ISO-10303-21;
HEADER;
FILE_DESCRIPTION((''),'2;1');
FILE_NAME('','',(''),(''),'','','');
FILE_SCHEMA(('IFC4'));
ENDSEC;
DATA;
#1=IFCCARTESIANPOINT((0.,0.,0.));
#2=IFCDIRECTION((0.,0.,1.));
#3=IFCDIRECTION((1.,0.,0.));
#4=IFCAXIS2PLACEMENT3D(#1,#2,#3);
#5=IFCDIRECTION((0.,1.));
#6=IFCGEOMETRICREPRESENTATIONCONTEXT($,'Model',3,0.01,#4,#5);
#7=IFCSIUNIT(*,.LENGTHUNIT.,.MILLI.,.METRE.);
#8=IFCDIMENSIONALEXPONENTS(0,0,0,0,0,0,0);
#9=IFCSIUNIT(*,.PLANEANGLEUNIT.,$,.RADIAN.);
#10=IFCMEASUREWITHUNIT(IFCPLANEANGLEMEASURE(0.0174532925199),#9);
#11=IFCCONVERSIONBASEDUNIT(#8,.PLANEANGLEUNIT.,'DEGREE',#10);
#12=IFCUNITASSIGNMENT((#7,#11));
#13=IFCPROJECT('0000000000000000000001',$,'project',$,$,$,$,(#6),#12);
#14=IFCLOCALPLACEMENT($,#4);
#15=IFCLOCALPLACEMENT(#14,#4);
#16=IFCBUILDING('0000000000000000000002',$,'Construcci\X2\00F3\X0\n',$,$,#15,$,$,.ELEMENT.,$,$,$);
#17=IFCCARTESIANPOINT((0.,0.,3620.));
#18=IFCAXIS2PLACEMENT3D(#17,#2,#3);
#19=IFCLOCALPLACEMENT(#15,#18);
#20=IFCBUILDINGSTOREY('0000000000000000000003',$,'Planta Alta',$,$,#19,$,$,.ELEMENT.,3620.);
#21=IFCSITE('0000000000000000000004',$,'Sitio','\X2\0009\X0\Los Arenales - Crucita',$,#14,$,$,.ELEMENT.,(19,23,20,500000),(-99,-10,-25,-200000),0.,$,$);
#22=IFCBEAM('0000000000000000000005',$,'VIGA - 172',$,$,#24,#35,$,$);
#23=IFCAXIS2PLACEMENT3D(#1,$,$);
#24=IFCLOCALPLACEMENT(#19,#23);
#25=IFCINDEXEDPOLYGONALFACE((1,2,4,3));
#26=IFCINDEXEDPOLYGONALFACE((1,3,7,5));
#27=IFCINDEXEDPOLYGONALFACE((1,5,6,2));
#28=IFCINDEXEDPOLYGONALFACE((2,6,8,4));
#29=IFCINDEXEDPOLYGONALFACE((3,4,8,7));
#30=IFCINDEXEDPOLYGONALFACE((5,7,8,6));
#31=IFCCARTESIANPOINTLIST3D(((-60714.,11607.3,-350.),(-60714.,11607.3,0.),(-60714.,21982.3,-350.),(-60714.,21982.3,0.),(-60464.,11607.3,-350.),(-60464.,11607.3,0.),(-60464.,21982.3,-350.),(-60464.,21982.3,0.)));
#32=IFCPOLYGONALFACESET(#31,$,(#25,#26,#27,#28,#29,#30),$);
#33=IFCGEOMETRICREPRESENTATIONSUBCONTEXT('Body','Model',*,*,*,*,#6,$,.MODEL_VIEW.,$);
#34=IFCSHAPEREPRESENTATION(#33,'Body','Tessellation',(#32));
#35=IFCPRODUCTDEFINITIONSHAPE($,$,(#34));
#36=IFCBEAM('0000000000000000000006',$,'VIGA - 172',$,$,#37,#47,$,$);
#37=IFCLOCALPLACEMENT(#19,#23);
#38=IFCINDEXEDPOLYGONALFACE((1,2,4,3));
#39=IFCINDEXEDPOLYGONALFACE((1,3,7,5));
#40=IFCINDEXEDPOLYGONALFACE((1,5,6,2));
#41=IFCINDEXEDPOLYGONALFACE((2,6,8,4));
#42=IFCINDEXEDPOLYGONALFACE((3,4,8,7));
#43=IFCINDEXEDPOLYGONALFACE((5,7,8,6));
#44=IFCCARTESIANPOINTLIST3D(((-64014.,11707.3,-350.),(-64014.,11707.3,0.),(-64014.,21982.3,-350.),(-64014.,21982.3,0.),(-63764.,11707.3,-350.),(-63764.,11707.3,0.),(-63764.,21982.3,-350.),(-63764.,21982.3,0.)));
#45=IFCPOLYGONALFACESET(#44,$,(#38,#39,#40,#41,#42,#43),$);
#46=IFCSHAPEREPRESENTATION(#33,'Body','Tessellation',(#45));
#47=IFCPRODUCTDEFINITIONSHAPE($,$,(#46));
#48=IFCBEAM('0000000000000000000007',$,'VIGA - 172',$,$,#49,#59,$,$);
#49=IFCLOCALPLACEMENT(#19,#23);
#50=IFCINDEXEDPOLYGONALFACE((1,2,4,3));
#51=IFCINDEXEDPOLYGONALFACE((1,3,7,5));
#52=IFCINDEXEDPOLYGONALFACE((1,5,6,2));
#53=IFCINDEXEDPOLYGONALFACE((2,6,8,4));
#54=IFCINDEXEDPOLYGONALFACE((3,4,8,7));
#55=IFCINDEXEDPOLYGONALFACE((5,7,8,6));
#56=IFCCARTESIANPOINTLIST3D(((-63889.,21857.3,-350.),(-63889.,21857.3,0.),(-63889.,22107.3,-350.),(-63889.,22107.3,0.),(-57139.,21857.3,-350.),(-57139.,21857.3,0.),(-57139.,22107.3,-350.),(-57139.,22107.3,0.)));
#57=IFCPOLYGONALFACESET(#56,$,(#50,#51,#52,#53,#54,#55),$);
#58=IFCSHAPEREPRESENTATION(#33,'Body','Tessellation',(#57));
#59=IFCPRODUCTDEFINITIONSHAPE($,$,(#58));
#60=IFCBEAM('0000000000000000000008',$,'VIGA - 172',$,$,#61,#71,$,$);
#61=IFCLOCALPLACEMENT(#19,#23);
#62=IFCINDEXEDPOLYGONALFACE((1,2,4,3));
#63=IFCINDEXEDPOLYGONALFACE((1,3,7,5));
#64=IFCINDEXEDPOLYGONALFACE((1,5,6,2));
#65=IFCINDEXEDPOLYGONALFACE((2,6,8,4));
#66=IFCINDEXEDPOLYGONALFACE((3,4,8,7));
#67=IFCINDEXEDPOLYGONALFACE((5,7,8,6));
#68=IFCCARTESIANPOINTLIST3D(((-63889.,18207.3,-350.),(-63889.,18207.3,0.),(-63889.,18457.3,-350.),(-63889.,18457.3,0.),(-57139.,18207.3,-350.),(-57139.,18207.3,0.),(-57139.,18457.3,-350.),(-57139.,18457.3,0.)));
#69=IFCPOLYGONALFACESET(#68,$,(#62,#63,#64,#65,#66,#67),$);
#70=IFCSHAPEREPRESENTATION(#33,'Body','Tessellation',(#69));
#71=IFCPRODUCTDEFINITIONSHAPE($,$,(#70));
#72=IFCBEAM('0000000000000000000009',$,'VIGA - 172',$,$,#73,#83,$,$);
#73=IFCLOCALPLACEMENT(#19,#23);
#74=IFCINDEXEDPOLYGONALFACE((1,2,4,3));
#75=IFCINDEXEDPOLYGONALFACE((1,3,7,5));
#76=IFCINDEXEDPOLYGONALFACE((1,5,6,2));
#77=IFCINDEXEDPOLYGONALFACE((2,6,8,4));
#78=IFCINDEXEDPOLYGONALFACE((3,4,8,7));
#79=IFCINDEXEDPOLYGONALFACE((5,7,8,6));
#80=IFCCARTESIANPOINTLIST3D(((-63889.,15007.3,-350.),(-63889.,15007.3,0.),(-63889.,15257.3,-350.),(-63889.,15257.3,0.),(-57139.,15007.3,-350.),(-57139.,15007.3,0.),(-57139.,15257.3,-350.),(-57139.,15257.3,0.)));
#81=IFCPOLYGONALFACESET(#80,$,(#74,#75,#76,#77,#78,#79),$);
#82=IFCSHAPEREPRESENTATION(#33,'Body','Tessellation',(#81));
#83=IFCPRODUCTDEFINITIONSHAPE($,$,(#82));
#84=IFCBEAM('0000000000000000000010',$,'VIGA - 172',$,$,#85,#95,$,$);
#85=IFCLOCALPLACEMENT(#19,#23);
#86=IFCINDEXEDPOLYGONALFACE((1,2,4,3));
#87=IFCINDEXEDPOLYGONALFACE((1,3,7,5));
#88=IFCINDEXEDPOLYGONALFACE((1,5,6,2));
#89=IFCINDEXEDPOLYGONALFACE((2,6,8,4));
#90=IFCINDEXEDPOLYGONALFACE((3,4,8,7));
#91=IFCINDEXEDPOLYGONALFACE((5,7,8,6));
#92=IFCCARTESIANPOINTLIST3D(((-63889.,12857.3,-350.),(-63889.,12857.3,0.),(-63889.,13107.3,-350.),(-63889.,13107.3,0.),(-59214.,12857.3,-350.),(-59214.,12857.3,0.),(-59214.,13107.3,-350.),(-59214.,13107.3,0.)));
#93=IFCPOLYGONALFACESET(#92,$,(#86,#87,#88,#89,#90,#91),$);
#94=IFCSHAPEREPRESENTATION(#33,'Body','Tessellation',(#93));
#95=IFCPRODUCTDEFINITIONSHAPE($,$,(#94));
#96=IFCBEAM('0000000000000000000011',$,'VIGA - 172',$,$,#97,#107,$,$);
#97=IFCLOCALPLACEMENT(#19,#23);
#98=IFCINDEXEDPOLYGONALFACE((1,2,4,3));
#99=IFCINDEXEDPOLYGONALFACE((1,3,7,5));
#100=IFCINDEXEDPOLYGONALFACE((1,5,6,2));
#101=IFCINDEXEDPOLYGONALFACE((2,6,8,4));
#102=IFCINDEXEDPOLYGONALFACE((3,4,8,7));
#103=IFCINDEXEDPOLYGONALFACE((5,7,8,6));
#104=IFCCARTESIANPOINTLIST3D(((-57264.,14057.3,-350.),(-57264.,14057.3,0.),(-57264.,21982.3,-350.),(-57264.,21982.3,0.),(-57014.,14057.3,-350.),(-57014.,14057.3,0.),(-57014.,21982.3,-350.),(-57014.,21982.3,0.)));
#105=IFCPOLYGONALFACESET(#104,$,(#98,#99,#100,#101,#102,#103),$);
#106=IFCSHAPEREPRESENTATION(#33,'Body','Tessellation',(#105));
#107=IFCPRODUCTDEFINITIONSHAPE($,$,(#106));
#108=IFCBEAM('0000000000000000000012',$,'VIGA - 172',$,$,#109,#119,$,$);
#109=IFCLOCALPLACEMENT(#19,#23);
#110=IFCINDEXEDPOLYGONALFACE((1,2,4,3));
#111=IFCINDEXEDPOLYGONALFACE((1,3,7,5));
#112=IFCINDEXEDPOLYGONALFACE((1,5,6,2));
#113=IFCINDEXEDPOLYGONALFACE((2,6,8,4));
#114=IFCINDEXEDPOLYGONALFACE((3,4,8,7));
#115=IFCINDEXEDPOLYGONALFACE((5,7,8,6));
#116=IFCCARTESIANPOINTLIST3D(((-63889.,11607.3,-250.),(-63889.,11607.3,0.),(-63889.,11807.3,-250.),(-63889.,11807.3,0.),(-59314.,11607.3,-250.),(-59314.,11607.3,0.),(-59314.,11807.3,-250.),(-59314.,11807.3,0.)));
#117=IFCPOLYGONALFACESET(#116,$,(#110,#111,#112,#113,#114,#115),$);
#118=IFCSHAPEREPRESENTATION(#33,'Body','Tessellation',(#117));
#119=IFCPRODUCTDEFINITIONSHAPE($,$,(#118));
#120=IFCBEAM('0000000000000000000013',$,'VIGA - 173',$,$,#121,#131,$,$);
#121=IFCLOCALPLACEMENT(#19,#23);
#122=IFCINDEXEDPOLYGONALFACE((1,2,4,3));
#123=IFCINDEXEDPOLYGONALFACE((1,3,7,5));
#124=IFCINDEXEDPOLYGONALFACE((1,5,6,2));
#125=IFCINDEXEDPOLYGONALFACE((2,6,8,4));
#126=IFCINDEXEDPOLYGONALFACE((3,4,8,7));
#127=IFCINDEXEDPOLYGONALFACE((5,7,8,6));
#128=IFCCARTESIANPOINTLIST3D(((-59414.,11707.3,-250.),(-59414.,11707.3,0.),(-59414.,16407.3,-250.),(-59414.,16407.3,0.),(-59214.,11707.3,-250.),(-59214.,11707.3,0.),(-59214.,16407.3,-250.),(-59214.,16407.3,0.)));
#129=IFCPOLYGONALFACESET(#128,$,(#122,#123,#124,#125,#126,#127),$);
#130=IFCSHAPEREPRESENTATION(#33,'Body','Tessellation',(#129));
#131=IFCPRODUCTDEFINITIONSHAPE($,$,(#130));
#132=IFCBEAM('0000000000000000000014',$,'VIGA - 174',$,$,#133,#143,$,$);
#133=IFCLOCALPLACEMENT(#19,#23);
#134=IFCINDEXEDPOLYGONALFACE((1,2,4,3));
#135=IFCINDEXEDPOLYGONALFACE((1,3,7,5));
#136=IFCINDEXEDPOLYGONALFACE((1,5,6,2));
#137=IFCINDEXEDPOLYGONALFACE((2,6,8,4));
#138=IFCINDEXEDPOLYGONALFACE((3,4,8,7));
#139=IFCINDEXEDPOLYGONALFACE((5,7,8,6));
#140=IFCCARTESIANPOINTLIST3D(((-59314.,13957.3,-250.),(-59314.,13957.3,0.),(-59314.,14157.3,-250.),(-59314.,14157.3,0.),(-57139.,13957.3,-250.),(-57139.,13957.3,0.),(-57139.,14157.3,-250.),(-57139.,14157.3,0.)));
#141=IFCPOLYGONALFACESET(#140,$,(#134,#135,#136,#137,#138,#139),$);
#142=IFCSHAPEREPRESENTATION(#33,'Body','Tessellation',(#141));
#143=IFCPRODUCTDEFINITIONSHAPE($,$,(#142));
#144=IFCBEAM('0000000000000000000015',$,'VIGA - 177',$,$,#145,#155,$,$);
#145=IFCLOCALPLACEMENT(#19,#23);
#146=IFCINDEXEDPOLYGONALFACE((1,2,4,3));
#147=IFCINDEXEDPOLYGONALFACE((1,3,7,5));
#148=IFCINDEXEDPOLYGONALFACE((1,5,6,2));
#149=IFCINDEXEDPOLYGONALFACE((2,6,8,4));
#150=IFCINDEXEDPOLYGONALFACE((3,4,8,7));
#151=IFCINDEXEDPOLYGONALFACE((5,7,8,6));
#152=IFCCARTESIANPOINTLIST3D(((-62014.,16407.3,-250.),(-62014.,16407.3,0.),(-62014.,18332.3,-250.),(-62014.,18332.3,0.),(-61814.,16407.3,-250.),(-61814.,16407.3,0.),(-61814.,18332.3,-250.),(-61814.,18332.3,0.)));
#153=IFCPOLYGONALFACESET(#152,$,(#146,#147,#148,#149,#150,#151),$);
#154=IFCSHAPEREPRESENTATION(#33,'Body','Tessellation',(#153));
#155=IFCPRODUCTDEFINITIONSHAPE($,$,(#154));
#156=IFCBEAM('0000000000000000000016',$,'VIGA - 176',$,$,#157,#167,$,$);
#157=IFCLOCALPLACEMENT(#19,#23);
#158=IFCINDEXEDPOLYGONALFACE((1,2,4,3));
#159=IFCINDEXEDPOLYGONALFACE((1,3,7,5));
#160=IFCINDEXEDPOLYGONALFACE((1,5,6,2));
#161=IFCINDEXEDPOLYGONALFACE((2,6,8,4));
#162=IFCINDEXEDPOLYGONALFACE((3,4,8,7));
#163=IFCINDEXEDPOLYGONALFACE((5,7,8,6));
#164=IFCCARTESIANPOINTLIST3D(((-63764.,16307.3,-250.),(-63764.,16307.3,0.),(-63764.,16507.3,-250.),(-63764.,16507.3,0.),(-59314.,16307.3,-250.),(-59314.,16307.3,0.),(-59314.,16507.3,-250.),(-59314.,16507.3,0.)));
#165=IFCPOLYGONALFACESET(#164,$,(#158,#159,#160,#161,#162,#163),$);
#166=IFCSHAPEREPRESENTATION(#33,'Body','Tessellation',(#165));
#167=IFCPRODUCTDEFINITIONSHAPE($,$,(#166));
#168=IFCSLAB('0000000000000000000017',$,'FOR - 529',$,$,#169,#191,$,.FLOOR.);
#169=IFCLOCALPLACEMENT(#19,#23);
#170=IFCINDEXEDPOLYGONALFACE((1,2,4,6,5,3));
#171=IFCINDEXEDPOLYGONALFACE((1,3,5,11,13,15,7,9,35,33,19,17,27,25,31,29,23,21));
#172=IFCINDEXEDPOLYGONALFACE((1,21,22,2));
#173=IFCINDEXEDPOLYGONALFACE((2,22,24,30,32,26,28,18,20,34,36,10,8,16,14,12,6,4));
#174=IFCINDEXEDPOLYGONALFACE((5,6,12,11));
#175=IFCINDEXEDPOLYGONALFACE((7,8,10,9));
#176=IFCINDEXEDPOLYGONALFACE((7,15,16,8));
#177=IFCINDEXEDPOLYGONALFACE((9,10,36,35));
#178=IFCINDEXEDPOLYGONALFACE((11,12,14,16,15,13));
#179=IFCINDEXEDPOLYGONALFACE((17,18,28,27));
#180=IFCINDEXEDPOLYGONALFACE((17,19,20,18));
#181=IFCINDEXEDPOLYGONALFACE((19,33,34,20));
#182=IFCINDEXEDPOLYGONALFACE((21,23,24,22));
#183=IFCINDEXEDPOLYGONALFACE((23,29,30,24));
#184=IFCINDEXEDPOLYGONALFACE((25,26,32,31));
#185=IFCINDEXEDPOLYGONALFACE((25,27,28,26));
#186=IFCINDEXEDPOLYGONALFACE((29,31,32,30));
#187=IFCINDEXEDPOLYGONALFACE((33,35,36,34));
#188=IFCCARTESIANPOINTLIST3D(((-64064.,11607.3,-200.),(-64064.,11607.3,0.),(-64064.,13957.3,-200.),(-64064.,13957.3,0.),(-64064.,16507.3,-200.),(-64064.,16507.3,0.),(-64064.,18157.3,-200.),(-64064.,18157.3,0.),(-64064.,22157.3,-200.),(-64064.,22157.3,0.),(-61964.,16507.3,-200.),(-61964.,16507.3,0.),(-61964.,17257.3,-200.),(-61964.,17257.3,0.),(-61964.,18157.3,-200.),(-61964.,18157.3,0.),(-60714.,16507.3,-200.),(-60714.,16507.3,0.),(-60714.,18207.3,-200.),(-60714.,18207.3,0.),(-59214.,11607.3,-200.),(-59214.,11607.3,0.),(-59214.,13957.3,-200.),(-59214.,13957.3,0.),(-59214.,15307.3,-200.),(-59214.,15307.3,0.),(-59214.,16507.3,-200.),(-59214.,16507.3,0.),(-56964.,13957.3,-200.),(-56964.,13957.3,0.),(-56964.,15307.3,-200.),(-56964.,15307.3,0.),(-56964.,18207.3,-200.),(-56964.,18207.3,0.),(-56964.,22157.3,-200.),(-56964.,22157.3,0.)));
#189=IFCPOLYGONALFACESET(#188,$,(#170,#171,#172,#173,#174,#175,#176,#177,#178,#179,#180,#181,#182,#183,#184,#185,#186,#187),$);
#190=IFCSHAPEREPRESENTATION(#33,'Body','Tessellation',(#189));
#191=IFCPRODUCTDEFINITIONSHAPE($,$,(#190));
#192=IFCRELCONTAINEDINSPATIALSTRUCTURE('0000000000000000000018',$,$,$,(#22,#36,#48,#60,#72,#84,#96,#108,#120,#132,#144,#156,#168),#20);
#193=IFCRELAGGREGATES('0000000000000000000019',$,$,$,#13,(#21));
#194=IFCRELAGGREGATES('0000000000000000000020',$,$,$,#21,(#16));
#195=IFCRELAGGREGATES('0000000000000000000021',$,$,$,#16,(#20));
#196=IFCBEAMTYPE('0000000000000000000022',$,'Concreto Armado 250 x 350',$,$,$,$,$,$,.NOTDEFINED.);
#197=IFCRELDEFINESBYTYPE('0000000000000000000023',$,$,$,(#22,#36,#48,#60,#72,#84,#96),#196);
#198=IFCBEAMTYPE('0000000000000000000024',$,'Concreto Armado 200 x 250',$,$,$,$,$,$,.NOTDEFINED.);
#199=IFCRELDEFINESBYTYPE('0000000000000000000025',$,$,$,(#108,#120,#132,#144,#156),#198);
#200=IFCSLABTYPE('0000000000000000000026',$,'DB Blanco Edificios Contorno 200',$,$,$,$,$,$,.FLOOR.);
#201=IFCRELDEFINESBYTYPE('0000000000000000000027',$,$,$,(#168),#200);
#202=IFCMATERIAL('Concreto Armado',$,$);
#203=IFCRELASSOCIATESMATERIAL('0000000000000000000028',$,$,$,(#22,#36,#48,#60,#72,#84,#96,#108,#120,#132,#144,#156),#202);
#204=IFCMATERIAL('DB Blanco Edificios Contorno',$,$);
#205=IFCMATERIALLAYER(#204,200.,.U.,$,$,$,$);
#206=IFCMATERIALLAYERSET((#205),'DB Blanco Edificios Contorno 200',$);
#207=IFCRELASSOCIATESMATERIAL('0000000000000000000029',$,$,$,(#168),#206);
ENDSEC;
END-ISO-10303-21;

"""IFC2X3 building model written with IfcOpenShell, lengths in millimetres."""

from ifc_helpers import new_model, entity, si_unit, converted_unit, direction, frame, frame_2d, origin_with_axes, place, context, subcontext, project, spatial, polyline, rectangle, outline, extrude, material, layer, layer_set, layer_usage, type_object, element, save


model = new_model("IFC2X3")

# Units and contexts
model_context = context("Model", 3, precision=0.01, world=origin_with_axes(), true_north=direction((0.0, 1.0)))
body_context = subcontext(model_context, "Body", "Model", "MODEL_VIEW")
ifc_project = project(units=[si_unit("LENGTHUNIT", "METRE", prefix="MILLI"), converted_unit("PLANEANGLEUNIT", "DEGREE", entity("IfcPlaneAngleMeasure", 0.0174532925199), si_unit("PLANEANGLEUNIT", "RADIAN"), dimensions=[0, 0, 0, 0, 0, 0, 0])], contexts=[model_context])

# Site, building, storey
site_placement = place(None, origin_with_axes())
site = spatial("IfcSite", under=ifc_project, at=site_placement, Name="Sitio", Description="\tLos Arenales - Crucita", CompositionType="ELEMENT", RefLatitude=(19, 23, 20, 500000), RefLongitude=(-99, -10, -25, -200000), RefElevation=0.0)
building_placement = place(site_placement, origin_with_axes())
building = spatial("IfcBuilding", under=site, at=building_placement, Name="Construcción", CompositionType="ELEMENT")
storey_placement = place(building_placement, frame((0.0, 0.0, 3620.0), z_axis=(0.0, 0.0, 1.0), x_axis=(1.0, 0.0, 0.0)))
storey = spatial("IfcBuildingStorey", under=building, at=storey_placement, Name="Planta Alta", CompositionType="ELEMENT", Elevation=3620.0)

# Beams
ifc_material_1 = material(Name="Concreto Armado")
beam_type_1 = type_object("IfcBeamType", Name="Concreto Armado 250 x 350", PredefinedType="NOTDEFINED")
beam_1_placement = place(storey_placement, frame((-60589.0, 21982.3, 0.0), z_axis=(0.0, 0.0, 1.0), x_axis=(-1.0, 0.0, 0.0)))
element("IfcBeam", 1, at=beam_1_placement, inside=storey, type_object=beam_type_1, material=ifc_material_1, Name="VIGA - 172", context=body_context, shape_type="SweptSolid", body=[
    extrude(rectangle(XDim=350.0, YDim=250.0, at=frame_2d((-175.0, 0.0), x_axis=(1.0, 0.0))), frame((0.0, 0.0, 0.0), z_axis=(0.0, 1.0, 0.0), x_axis=(0.0, 0.0, 1.0)), (0.0, 0.0, 1.0), 10375.0),
])
beam_2_placement = place(storey_placement, frame((-63889.0, 21982.3, 0.0), z_axis=(0.0, 0.0, 1.0), x_axis=(-1.0, 0.0, 0.0)))
element("IfcBeam", 2, at=beam_2_placement, inside=storey, type_object=beam_type_1, material=ifc_material_1, Name="VIGA - 172", context=body_context, shape_type="SweptSolid", body=[
    extrude(rectangle(XDim=350.0, YDim=250.0, at=frame_2d((-175.0, 0.0), x_axis=(1.0, 0.0))), frame((0.0, 0.0, 0.0), z_axis=(0.0, 1.0, 0.0), x_axis=(0.0, 0.0, 1.0)), (0.0, 0.0, 1.0), 10275.0),
])
for number, where, z_axis, x_axis, name in (
    (3, (-57139.0, 21982.3, 0.0), (0.0, 0.0, 1.0), (0.0, 1.0, 0.0), "VIGA - 172"),
    (4, (-57139.0, 18332.3, 0.0), (0.0, 0.0, 1.0), (0.0, 1.0, 0.0), "VIGA - 172"),
    (5, (-57139.0, 15132.3, 0.0), (0.0, 0.0, 1.0), (0.0, 1.0, 0.0), "VIGA - 172"),
):
    element("IfcBeam", number, at=place(storey_placement, frame(where, z_axis=z_axis, x_axis=x_axis)), inside=storey, type_object=beam_type_1, material=ifc_material_1, Name=name, context=body_context, shape_type="SweptSolid", body=[
        extrude(rectangle(XDim=350.0, YDim=250.0, at=frame_2d((-175.0, 0.0), x_axis=(1.0, 0.0))), frame((0.0, 0.0, 0.0), z_axis=(0.0, 1.0, 0.0), x_axis=(0.0, 0.0, 1.0)), (0.0, 0.0, 1.0), 6750.0),
    ])
beam_3_placement = place(storey_placement, frame((-59214.0, 12982.3, 0.0), z_axis=(0.0, 0.0, 1.0), x_axis=(0.0, 1.0, 0.0)))
element("IfcBeam", 6, at=beam_3_placement, inside=storey, type_object=beam_type_1, material=ifc_material_1, Name="VIGA - 172", context=body_context, shape_type="SweptSolid", body=[
    extrude(rectangle(XDim=350.0, YDim=250.0, at=frame_2d((-175.0, 0.0), x_axis=(1.0, 0.0))), frame((0.0, 0.0, 0.0), z_axis=(0.0, 1.0, 0.0), x_axis=(0.0, 0.0, 1.0)), (0.0, 0.0, 1.0), 4675.0),
])
beam_4_placement = place(storey_placement, frame((-57139.0, 21982.3, 0.0), z_axis=(0.0, 0.0, 1.0), x_axis=(-1.0, 0.0, 0.0)))
element("IfcBeam", 7, at=beam_4_placement, inside=storey, type_object=beam_type_1, material=ifc_material_1, Name="VIGA - 172", context=body_context, shape_type="SweptSolid", body=[
    extrude(rectangle(XDim=350.0, YDim=250.0, at=frame_2d((-175.0, 0.0), x_axis=(1.0, 0.0))), frame((0.0, 0.0, 0.0), z_axis=(0.0, 1.0, 0.0), x_axis=(0.0, 0.0, 1.0)), (0.0, 0.0, 1.0), 7925.0),
])
beam_type_2 = type_object("IfcBeamType", Name="Concreto Armado 200 x 250", PredefinedType="NOTDEFINED")
beam_5_placement = place(storey_placement, frame((-63889.0, 11707.3, 0.0), z_axis=(0.0, 0.0, 1.0), x_axis=(0.0, -1.0, 0.0)))
element("IfcBeam", 8, at=beam_5_placement, inside=storey, type_object=beam_type_2, material=ifc_material_1, Name="VIGA - 172", context=body_context, shape_type="SweptSolid", body=[
    extrude(rectangle(XDim=250.0, YDim=200.0, at=frame_2d((-125.0, 0.0), x_axis=(1.0, 0.0))), frame((0.0, 0.0, 0.0), z_axis=(0.0, 1.0, 0.0), x_axis=(0.0, 0.0, 1.0)), (0.0, 0.0, 1.0), 4575.0),
])
beam_6_placement = place(storey_placement, frame((-59314.0, 11707.3, 0.0), z_axis=(0.0, 0.0, 1.0), x_axis=(1.0, 0.0, 0.0)))
element("IfcBeam", 9, at=beam_6_placement, inside=storey, type_object=beam_type_2, material=ifc_material_1, Name="VIGA - 173", context=body_context, shape_type="SweptSolid", body=[
    extrude(rectangle(XDim=250.0, YDim=200.0, at=frame_2d((-125.0, 0.0), x_axis=(1.0, 0.0))), frame((0.0, 0.0, 0.0), z_axis=(0.0, 1.0, 0.0), x_axis=(0.0, 0.0, 1.0)), (0.0, 0.0, 1.0), 4700.0),
])
beam_7_placement = place(storey_placement, frame((-57139.0, 14057.3, 0.0), z_axis=(0.0, 0.0, 1.0), x_axis=(0.0, 1.0, 0.0)))
element("IfcBeam", 10, at=beam_7_placement, inside=storey, type_object=beam_type_2, material=ifc_material_1, Name="VIGA - 174", context=body_context, shape_type="SweptSolid", body=[
    extrude(rectangle(XDim=250.0, YDim=200.0, at=frame_2d((-125.0, 0.0), x_axis=(1.0, 0.0))), frame((0.0, 0.0, 0.0), z_axis=(0.0, 1.0, 0.0), x_axis=(0.0, 0.0, 1.0)), (0.0, 0.0, 1.0), 2175.0),
])
beam_8_placement = place(storey_placement, frame((-61914.0, 18332.3, 0.0), z_axis=(0.0, 0.0, 1.0), x_axis=(-1.0, 0.0, 0.0)))
element("IfcBeam", 11, at=beam_8_placement, inside=storey, type_object=beam_type_2, material=ifc_material_1, Name="VIGA - 177", context=body_context, shape_type="SweptSolid", body=[
    extrude(rectangle(XDim=250.0, YDim=200.0, at=frame_2d((-125.0, 0.0), x_axis=(1.0, 0.0))), frame((0.0, 0.0, 0.0), z_axis=(0.0, 1.0, 0.0), x_axis=(0.0, 0.0, 1.0)), (0.0, 0.0, 1.0), 1925.0),
])
beam_9_placement = place(storey_placement, frame((-59314.0, 16407.3, 0.0), z_axis=(0.0, 0.0, 1.0), x_axis=(0.0, 1.0, 0.0)))
element("IfcBeam", 12, at=beam_9_placement, inside=storey, type_object=beam_type_2, material=ifc_material_1, Name="VIGA - 176", context=body_context, shape_type="SweptSolid", body=[
    extrude(rectangle(XDim=250.0, YDim=200.0, at=frame_2d((-125.0, 0.0), x_axis=(1.0, 0.0))), frame((0.0, 0.0, 0.0), z_axis=(0.0, 1.0, 0.0), x_axis=(0.0, 0.0, 1.0)), (0.0, 0.0, 1.0), 4450.0),
])

# Slab
ifc_material_2 = material(Name="DB Blanco Edificios Contorno")
ifc_layer = layer(ifc_material_2, 200.0, ventilated="UNKNOWN")
ifc_layer_set = layer_set([ifc_layer], Name="DB Blanco Edificios Contorno 200")
ifc_layer_usage = layer_usage(ifc_layer_set, "AXIS3", "NEGATIVE", 200.0)
slab_type = type_object("IfcSlabType", Name="DB Blanco Edificios Contorno 200", PredefinedType="FLOOR")
slab_placement = place(storey_placement, frame((-64064.0, 22157.3, 0.0), z_axis=(0.0, 0.0, 1.0), x_axis=(1.0, 0.0, 0.0)))
element("IfcSlab", 13, at=slab_placement, inside=storey, type_object=slab_type, material=ifc_layer_usage, Name="FOR - 529", PredefinedType="FLOOR", context=body_context, shape_type="SweptSolid", body=[
    extrude(outline(polyline([(0.0, 0.0), (0.0, -4000.0), (2100.0, -4000.0), (2100.0, -4900.0), (2100.0, -5650.0), (0.0, -5650.0), (0.0, -8200.0), (0.0, -10550.0), (4850.0, -10550.0), (4850.0, -8200.0), (7100.0, -8200.0), (7100.0, -6850.0), (4850.0, -6850.0), (4850.0, -5650.0), (3350.0, -5650.0), (3350.0, -3950.0), (7100.0, -3950.0), (7100.0, 0.0), (0.0, 0.0)])), frame((0.0, 0.0, -200.0), z_axis=(0.0, 0.0, 1.0), x_axis=(1.0, 0.0, 0.0)), (0.0, 0.0, 1.0), 200.0),
])

save(model, "model.ifc")
